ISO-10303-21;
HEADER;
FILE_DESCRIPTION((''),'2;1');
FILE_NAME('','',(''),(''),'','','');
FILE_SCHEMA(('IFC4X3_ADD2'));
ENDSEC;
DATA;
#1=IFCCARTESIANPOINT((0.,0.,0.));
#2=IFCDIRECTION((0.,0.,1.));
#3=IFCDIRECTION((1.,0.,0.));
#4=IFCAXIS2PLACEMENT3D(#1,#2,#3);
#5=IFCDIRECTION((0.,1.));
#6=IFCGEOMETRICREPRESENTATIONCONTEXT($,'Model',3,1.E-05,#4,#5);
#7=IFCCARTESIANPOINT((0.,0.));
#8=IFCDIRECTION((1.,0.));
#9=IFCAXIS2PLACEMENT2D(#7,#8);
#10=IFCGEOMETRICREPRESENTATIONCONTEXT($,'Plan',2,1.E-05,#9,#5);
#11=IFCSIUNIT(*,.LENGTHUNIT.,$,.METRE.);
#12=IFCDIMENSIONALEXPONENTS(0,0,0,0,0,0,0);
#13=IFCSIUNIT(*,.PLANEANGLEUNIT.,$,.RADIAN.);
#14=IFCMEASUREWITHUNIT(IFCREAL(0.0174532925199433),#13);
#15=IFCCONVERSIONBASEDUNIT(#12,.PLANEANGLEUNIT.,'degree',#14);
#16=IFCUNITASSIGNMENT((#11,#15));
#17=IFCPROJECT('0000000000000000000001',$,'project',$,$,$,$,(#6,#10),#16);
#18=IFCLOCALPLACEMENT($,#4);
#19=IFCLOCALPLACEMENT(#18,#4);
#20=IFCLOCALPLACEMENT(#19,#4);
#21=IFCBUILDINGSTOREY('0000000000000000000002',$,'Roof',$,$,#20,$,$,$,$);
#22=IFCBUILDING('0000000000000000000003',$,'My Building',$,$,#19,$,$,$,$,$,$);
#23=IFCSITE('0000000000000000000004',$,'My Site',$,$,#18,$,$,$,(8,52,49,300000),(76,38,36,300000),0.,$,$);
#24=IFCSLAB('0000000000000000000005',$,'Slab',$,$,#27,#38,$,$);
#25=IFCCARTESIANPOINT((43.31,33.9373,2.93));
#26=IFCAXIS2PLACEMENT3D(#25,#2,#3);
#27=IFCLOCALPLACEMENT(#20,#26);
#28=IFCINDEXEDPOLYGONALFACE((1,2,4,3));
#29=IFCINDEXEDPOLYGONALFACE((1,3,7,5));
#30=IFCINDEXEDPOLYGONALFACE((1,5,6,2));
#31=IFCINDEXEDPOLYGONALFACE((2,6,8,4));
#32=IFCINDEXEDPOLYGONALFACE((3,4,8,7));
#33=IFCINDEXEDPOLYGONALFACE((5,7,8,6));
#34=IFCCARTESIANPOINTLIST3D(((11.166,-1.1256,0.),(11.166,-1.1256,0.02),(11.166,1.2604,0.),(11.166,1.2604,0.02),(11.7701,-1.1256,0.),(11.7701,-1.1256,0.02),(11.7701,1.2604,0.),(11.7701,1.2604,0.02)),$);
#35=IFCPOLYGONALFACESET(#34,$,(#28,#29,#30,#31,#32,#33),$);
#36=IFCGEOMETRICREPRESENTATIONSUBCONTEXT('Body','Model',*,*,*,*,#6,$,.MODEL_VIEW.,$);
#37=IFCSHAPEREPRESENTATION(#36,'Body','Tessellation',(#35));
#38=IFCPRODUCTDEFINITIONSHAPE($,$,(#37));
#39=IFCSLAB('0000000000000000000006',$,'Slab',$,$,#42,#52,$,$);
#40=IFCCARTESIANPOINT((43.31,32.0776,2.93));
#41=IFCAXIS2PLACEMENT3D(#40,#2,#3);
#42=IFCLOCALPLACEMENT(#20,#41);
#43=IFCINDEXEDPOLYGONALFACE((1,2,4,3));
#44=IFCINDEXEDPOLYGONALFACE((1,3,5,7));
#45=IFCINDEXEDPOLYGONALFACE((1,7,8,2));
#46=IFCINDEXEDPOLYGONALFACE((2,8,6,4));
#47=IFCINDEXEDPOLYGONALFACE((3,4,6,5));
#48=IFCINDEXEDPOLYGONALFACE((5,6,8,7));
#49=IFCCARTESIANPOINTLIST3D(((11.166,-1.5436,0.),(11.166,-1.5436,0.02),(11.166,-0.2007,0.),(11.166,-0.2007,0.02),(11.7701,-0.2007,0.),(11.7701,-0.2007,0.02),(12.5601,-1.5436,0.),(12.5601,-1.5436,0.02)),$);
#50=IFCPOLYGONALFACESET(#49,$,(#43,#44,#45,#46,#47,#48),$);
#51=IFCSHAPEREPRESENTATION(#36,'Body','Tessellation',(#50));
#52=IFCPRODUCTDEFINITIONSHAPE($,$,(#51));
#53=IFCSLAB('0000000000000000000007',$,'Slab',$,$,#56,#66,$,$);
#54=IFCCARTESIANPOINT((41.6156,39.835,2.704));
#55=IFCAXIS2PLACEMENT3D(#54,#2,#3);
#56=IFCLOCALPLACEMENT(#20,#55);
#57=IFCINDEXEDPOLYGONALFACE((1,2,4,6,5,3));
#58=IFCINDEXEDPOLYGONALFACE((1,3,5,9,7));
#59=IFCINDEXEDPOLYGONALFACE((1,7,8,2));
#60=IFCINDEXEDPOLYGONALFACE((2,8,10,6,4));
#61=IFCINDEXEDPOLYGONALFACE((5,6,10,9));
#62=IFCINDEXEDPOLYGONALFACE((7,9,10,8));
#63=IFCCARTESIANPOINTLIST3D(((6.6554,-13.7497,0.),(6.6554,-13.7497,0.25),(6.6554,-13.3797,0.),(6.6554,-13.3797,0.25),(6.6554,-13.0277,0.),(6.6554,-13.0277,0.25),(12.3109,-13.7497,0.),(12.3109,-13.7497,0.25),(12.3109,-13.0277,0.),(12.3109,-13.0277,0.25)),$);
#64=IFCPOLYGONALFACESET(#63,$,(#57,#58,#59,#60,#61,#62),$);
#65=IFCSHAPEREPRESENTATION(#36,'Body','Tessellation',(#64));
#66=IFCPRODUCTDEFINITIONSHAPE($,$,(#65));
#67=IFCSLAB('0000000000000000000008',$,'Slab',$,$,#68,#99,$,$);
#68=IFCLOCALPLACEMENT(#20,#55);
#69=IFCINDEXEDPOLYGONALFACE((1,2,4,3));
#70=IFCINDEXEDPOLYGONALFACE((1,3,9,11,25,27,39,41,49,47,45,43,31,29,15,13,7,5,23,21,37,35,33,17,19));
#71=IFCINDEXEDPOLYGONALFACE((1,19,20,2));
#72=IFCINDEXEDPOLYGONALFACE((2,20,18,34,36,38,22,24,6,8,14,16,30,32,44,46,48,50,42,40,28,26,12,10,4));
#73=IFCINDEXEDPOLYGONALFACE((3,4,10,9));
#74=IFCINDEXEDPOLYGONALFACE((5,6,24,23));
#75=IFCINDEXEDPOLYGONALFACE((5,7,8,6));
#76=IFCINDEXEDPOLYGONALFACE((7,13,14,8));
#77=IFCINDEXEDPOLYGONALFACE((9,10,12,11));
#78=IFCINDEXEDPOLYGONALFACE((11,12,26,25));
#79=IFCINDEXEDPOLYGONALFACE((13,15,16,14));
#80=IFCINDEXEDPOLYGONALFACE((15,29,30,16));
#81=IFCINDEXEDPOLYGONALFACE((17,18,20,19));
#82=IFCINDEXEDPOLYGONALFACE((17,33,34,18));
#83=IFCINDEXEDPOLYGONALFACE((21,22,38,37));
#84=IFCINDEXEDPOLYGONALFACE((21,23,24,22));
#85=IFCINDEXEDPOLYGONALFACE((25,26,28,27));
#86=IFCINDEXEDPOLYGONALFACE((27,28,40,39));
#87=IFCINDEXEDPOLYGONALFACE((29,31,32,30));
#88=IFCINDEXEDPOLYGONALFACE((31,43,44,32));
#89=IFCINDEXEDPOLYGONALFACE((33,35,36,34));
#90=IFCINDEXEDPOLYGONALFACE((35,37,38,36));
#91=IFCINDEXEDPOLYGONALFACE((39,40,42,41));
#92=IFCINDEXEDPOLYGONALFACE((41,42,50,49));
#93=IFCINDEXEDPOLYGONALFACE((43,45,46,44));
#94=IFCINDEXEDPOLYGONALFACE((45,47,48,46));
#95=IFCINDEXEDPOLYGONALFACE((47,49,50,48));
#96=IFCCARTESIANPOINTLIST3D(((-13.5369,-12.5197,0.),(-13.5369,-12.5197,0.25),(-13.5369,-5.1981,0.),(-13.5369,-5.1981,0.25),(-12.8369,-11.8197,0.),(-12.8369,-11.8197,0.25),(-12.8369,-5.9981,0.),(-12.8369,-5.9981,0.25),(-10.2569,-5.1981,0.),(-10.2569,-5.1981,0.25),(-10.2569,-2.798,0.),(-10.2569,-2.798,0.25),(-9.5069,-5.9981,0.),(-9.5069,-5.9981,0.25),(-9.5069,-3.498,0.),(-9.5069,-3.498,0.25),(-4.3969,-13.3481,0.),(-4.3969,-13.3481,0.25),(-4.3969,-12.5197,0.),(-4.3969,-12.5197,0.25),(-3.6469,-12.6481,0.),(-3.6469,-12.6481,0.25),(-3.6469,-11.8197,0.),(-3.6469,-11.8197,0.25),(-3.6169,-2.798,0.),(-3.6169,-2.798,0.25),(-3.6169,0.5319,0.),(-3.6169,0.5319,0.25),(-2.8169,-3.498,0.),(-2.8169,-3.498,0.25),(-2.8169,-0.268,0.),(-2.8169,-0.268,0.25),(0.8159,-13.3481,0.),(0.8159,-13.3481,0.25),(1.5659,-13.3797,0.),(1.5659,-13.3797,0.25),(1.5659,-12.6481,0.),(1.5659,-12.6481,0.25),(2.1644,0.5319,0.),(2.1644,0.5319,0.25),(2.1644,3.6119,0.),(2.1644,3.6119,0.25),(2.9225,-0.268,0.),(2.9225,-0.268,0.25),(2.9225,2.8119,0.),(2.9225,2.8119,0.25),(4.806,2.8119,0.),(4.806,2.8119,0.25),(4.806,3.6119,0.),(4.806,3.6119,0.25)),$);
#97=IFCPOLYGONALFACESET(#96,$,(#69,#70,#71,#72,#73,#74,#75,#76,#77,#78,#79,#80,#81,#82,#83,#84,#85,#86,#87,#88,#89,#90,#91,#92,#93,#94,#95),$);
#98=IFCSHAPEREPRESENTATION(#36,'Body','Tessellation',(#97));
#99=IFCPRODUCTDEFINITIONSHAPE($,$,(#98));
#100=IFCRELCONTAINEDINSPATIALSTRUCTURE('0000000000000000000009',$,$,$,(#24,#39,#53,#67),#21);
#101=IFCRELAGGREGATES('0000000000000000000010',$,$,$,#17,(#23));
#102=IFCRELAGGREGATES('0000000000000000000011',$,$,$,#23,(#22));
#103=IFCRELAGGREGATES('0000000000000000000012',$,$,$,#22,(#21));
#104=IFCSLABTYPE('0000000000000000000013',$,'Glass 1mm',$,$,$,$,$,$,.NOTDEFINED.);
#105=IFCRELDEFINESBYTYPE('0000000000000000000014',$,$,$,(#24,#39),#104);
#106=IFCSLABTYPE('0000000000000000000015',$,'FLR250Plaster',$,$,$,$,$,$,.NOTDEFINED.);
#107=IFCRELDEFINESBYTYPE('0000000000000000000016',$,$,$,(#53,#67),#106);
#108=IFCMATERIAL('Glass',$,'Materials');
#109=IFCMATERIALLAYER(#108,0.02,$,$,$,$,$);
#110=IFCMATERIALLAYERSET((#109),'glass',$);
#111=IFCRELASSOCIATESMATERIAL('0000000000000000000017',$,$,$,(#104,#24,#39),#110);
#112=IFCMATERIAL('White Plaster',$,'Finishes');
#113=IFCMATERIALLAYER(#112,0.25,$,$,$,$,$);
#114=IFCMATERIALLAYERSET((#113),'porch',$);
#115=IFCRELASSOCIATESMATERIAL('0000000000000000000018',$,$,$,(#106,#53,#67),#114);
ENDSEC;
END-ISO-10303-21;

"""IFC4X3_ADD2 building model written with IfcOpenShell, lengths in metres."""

from ifc_helpers import new_model, entity, si_unit, converted_unit, direction, frame, origin_with_axes, origin_2d_with_axis, place, context, subcontext, project, spatial, indexed_curve, outline, extrude, material, layer, layer_set, layer_usage, type_object, element, save


model = new_model("IFC4X3_ADD2")

# Units and contexts
model_context = context("Model", 3, precision=1e-05, world=origin_with_axes(), true_north=direction((0.0, 1.0)))
plan_context = context("Plan", 2, precision=1e-05, world=origin_2d_with_axis(), true_north=direction((0.0, 1.0)))
body_context = subcontext(model_context, "Body", "Model", "MODEL_VIEW")
ifc_project = project(units=[si_unit("LENGTHUNIT", "METRE"), converted_unit("PLANEANGLEUNIT", "degree", entity("IfcReal", 0.0174532925199433), si_unit("PLANEANGLEUNIT", "RADIAN"), dimensions=[0, 0, 0, 0, 0, 0, 0])], contexts=[model_context, plan_context])

# Site, building, storey
site_placement = place(None, origin_with_axes())
site = spatial("IfcSite", under=ifc_project, at=site_placement, Name="My Site", RefLatitude=(8, 52, 49, 300000), RefLongitude=(76, 38, 36, 300000), RefElevation=0.0)
building_placement = place(site_placement, origin_with_axes())
building = spatial("IfcBuilding", under=site, at=building_placement, Name="My Building")
storey_placement = place(building_placement, origin_with_axes())
storey = spatial("IfcBuildingStorey", under=building, at=storey_placement, Name="Roof")

# Slabs
ifc_material_1 = material(Name="White Plaster", Category="Finishes")
ifc_material_2 = material(Name="Glass", Category="Materials")
ifc_layer_1 = layer(ifc_material_2, 0.02)
ifc_layer_set_1 = layer_set([ifc_layer_1], Name="glass")
slab_type_1 = type_object("IfcSlabType", Name="Glass 1mm", PredefinedType="NOTDEFINED", material=ifc_layer_set_1)
ifc_layer_usage_1 = layer_usage(ifc_layer_set_1, "AXIS3", "POSITIVE", 0.0)
slab_1_placement = place(storey_placement, frame((43.31, 33.9373, 2.93), z_axis=(0.0, 0.0, 1.0), x_axis=(1.0, 0.0, 0.0)))
element("IfcSlab", 1, at=slab_1_placement, inside=storey, type_object=slab_type_1, material=ifc_layer_usage_1, Name="Slab", context=body_context, shape_type="SweptSolid", body=[
    extrude(outline(indexed_curve([(11.7701, 1.2604), (11.166, 1.2604), (11.166, -1.1256), (11.7701, -1.1256), (11.7701, 1.2604)])), origin_with_axes(), (0.0, 0.0, 1.0), 0.02),
])
ifc_layer_usage_2 = layer_usage(ifc_layer_set_1, "AXIS3", "POSITIVE", 0.0)
slab_2_placement = place(storey_placement, frame((43.31, 32.0776, 2.93), z_axis=(0.0, 0.0, 1.0), x_axis=(1.0, 0.0, 0.0)))
element("IfcSlab", 2, at=slab_2_placement, inside=storey, type_object=slab_type_1, material=ifc_layer_usage_2, Name="Slab", context=body_context, shape_type="SweptSolid", body=[
    extrude(outline(indexed_curve([(12.5601, -1.5436), (11.166, -1.5436), (11.166, -0.2007), (11.7701, -0.2007), (12.5601, -1.5436)])), origin_with_axes(), (0.0, 0.0, 1.0), 0.02),
])
ifc_layer_2 = layer(ifc_material_1, 0.25)
ifc_layer_set_2 = layer_set([ifc_layer_2], Name="porch")
ifc_layer_usage_3 = layer_usage(ifc_layer_set_2, "AXIS3", "POSITIVE", 0.0)
slab_type_2 = type_object("IfcSlabType", Name="FLR250Plaster", PredefinedType="NOTDEFINED", material=ifc_layer_set_2)
slab_3_placement = place(storey_placement, frame((41.6156, 39.835, 2.704), z_axis=(0.0, 0.0, 1.0), x_axis=(1.0, 0.0, 0.0)))
element("IfcSlab", 3, at=slab_3_placement, inside=storey, type_object=slab_type_2, material=ifc_layer_usage_3, Name="Slab", context=body_context, shape_type="SweptSolid", body=[
    extrude(outline(indexed_curve([(6.6554, -13.0277), (12.3109, -13.0277), (12.3109, -13.7497), (6.6554, -13.7497), (6.6554, -13.3797), (6.6554, -13.0277)])), origin_with_axes(), (0.0, 0.0, 1.0), 0.25),
])
ifc_layer_usage_4 = layer_usage(ifc_layer_set_2, "AXIS3", "POSITIVE", 0.0)
slab_4_placement = place(storey_placement, frame((41.6156, 39.835, 2.704), z_axis=(0.0, 0.0, 1.0), x_axis=(1.0, 0.0, 0.0)))
element("IfcSlab", 4, at=slab_4_placement, inside=storey, type_object=slab_type_2, material=ifc_layer_usage_4, Name="Slab", context=body_context, shape_type="SweptSolid", body=[
    extrude(outline(indexed_curve([(0.8159, -13.3481), (-4.3969, -13.3481), (-4.3969, -12.5197), (-13.5369, -12.5197), (-13.5369, -5.1981), (-10.2569, -5.1981), (-10.2569, -2.798), (-3.6169, -2.798), (-3.6169, 0.5319), (2.1644, 0.5319), (2.1644, 3.6119), (4.806, 3.6119), (4.806, 2.8119), (2.9225, 2.8119), (2.9225, -0.268), (-2.8169, -0.268), (-2.8169, -3.498), (-9.5069, -3.498), (-9.5069, -5.9981), (-12.8369, -5.9981), (-12.8369, -11.8197), (-3.6469, -11.8197), (-3.6469, -12.6481), (1.5659, -12.6481), (1.5659, -13.3797), (0.8159, -13.3481)])), origin_with_axes(), (0.0, 0.0, 1.0), 0.25),
])

save(model, "model.ifc")
